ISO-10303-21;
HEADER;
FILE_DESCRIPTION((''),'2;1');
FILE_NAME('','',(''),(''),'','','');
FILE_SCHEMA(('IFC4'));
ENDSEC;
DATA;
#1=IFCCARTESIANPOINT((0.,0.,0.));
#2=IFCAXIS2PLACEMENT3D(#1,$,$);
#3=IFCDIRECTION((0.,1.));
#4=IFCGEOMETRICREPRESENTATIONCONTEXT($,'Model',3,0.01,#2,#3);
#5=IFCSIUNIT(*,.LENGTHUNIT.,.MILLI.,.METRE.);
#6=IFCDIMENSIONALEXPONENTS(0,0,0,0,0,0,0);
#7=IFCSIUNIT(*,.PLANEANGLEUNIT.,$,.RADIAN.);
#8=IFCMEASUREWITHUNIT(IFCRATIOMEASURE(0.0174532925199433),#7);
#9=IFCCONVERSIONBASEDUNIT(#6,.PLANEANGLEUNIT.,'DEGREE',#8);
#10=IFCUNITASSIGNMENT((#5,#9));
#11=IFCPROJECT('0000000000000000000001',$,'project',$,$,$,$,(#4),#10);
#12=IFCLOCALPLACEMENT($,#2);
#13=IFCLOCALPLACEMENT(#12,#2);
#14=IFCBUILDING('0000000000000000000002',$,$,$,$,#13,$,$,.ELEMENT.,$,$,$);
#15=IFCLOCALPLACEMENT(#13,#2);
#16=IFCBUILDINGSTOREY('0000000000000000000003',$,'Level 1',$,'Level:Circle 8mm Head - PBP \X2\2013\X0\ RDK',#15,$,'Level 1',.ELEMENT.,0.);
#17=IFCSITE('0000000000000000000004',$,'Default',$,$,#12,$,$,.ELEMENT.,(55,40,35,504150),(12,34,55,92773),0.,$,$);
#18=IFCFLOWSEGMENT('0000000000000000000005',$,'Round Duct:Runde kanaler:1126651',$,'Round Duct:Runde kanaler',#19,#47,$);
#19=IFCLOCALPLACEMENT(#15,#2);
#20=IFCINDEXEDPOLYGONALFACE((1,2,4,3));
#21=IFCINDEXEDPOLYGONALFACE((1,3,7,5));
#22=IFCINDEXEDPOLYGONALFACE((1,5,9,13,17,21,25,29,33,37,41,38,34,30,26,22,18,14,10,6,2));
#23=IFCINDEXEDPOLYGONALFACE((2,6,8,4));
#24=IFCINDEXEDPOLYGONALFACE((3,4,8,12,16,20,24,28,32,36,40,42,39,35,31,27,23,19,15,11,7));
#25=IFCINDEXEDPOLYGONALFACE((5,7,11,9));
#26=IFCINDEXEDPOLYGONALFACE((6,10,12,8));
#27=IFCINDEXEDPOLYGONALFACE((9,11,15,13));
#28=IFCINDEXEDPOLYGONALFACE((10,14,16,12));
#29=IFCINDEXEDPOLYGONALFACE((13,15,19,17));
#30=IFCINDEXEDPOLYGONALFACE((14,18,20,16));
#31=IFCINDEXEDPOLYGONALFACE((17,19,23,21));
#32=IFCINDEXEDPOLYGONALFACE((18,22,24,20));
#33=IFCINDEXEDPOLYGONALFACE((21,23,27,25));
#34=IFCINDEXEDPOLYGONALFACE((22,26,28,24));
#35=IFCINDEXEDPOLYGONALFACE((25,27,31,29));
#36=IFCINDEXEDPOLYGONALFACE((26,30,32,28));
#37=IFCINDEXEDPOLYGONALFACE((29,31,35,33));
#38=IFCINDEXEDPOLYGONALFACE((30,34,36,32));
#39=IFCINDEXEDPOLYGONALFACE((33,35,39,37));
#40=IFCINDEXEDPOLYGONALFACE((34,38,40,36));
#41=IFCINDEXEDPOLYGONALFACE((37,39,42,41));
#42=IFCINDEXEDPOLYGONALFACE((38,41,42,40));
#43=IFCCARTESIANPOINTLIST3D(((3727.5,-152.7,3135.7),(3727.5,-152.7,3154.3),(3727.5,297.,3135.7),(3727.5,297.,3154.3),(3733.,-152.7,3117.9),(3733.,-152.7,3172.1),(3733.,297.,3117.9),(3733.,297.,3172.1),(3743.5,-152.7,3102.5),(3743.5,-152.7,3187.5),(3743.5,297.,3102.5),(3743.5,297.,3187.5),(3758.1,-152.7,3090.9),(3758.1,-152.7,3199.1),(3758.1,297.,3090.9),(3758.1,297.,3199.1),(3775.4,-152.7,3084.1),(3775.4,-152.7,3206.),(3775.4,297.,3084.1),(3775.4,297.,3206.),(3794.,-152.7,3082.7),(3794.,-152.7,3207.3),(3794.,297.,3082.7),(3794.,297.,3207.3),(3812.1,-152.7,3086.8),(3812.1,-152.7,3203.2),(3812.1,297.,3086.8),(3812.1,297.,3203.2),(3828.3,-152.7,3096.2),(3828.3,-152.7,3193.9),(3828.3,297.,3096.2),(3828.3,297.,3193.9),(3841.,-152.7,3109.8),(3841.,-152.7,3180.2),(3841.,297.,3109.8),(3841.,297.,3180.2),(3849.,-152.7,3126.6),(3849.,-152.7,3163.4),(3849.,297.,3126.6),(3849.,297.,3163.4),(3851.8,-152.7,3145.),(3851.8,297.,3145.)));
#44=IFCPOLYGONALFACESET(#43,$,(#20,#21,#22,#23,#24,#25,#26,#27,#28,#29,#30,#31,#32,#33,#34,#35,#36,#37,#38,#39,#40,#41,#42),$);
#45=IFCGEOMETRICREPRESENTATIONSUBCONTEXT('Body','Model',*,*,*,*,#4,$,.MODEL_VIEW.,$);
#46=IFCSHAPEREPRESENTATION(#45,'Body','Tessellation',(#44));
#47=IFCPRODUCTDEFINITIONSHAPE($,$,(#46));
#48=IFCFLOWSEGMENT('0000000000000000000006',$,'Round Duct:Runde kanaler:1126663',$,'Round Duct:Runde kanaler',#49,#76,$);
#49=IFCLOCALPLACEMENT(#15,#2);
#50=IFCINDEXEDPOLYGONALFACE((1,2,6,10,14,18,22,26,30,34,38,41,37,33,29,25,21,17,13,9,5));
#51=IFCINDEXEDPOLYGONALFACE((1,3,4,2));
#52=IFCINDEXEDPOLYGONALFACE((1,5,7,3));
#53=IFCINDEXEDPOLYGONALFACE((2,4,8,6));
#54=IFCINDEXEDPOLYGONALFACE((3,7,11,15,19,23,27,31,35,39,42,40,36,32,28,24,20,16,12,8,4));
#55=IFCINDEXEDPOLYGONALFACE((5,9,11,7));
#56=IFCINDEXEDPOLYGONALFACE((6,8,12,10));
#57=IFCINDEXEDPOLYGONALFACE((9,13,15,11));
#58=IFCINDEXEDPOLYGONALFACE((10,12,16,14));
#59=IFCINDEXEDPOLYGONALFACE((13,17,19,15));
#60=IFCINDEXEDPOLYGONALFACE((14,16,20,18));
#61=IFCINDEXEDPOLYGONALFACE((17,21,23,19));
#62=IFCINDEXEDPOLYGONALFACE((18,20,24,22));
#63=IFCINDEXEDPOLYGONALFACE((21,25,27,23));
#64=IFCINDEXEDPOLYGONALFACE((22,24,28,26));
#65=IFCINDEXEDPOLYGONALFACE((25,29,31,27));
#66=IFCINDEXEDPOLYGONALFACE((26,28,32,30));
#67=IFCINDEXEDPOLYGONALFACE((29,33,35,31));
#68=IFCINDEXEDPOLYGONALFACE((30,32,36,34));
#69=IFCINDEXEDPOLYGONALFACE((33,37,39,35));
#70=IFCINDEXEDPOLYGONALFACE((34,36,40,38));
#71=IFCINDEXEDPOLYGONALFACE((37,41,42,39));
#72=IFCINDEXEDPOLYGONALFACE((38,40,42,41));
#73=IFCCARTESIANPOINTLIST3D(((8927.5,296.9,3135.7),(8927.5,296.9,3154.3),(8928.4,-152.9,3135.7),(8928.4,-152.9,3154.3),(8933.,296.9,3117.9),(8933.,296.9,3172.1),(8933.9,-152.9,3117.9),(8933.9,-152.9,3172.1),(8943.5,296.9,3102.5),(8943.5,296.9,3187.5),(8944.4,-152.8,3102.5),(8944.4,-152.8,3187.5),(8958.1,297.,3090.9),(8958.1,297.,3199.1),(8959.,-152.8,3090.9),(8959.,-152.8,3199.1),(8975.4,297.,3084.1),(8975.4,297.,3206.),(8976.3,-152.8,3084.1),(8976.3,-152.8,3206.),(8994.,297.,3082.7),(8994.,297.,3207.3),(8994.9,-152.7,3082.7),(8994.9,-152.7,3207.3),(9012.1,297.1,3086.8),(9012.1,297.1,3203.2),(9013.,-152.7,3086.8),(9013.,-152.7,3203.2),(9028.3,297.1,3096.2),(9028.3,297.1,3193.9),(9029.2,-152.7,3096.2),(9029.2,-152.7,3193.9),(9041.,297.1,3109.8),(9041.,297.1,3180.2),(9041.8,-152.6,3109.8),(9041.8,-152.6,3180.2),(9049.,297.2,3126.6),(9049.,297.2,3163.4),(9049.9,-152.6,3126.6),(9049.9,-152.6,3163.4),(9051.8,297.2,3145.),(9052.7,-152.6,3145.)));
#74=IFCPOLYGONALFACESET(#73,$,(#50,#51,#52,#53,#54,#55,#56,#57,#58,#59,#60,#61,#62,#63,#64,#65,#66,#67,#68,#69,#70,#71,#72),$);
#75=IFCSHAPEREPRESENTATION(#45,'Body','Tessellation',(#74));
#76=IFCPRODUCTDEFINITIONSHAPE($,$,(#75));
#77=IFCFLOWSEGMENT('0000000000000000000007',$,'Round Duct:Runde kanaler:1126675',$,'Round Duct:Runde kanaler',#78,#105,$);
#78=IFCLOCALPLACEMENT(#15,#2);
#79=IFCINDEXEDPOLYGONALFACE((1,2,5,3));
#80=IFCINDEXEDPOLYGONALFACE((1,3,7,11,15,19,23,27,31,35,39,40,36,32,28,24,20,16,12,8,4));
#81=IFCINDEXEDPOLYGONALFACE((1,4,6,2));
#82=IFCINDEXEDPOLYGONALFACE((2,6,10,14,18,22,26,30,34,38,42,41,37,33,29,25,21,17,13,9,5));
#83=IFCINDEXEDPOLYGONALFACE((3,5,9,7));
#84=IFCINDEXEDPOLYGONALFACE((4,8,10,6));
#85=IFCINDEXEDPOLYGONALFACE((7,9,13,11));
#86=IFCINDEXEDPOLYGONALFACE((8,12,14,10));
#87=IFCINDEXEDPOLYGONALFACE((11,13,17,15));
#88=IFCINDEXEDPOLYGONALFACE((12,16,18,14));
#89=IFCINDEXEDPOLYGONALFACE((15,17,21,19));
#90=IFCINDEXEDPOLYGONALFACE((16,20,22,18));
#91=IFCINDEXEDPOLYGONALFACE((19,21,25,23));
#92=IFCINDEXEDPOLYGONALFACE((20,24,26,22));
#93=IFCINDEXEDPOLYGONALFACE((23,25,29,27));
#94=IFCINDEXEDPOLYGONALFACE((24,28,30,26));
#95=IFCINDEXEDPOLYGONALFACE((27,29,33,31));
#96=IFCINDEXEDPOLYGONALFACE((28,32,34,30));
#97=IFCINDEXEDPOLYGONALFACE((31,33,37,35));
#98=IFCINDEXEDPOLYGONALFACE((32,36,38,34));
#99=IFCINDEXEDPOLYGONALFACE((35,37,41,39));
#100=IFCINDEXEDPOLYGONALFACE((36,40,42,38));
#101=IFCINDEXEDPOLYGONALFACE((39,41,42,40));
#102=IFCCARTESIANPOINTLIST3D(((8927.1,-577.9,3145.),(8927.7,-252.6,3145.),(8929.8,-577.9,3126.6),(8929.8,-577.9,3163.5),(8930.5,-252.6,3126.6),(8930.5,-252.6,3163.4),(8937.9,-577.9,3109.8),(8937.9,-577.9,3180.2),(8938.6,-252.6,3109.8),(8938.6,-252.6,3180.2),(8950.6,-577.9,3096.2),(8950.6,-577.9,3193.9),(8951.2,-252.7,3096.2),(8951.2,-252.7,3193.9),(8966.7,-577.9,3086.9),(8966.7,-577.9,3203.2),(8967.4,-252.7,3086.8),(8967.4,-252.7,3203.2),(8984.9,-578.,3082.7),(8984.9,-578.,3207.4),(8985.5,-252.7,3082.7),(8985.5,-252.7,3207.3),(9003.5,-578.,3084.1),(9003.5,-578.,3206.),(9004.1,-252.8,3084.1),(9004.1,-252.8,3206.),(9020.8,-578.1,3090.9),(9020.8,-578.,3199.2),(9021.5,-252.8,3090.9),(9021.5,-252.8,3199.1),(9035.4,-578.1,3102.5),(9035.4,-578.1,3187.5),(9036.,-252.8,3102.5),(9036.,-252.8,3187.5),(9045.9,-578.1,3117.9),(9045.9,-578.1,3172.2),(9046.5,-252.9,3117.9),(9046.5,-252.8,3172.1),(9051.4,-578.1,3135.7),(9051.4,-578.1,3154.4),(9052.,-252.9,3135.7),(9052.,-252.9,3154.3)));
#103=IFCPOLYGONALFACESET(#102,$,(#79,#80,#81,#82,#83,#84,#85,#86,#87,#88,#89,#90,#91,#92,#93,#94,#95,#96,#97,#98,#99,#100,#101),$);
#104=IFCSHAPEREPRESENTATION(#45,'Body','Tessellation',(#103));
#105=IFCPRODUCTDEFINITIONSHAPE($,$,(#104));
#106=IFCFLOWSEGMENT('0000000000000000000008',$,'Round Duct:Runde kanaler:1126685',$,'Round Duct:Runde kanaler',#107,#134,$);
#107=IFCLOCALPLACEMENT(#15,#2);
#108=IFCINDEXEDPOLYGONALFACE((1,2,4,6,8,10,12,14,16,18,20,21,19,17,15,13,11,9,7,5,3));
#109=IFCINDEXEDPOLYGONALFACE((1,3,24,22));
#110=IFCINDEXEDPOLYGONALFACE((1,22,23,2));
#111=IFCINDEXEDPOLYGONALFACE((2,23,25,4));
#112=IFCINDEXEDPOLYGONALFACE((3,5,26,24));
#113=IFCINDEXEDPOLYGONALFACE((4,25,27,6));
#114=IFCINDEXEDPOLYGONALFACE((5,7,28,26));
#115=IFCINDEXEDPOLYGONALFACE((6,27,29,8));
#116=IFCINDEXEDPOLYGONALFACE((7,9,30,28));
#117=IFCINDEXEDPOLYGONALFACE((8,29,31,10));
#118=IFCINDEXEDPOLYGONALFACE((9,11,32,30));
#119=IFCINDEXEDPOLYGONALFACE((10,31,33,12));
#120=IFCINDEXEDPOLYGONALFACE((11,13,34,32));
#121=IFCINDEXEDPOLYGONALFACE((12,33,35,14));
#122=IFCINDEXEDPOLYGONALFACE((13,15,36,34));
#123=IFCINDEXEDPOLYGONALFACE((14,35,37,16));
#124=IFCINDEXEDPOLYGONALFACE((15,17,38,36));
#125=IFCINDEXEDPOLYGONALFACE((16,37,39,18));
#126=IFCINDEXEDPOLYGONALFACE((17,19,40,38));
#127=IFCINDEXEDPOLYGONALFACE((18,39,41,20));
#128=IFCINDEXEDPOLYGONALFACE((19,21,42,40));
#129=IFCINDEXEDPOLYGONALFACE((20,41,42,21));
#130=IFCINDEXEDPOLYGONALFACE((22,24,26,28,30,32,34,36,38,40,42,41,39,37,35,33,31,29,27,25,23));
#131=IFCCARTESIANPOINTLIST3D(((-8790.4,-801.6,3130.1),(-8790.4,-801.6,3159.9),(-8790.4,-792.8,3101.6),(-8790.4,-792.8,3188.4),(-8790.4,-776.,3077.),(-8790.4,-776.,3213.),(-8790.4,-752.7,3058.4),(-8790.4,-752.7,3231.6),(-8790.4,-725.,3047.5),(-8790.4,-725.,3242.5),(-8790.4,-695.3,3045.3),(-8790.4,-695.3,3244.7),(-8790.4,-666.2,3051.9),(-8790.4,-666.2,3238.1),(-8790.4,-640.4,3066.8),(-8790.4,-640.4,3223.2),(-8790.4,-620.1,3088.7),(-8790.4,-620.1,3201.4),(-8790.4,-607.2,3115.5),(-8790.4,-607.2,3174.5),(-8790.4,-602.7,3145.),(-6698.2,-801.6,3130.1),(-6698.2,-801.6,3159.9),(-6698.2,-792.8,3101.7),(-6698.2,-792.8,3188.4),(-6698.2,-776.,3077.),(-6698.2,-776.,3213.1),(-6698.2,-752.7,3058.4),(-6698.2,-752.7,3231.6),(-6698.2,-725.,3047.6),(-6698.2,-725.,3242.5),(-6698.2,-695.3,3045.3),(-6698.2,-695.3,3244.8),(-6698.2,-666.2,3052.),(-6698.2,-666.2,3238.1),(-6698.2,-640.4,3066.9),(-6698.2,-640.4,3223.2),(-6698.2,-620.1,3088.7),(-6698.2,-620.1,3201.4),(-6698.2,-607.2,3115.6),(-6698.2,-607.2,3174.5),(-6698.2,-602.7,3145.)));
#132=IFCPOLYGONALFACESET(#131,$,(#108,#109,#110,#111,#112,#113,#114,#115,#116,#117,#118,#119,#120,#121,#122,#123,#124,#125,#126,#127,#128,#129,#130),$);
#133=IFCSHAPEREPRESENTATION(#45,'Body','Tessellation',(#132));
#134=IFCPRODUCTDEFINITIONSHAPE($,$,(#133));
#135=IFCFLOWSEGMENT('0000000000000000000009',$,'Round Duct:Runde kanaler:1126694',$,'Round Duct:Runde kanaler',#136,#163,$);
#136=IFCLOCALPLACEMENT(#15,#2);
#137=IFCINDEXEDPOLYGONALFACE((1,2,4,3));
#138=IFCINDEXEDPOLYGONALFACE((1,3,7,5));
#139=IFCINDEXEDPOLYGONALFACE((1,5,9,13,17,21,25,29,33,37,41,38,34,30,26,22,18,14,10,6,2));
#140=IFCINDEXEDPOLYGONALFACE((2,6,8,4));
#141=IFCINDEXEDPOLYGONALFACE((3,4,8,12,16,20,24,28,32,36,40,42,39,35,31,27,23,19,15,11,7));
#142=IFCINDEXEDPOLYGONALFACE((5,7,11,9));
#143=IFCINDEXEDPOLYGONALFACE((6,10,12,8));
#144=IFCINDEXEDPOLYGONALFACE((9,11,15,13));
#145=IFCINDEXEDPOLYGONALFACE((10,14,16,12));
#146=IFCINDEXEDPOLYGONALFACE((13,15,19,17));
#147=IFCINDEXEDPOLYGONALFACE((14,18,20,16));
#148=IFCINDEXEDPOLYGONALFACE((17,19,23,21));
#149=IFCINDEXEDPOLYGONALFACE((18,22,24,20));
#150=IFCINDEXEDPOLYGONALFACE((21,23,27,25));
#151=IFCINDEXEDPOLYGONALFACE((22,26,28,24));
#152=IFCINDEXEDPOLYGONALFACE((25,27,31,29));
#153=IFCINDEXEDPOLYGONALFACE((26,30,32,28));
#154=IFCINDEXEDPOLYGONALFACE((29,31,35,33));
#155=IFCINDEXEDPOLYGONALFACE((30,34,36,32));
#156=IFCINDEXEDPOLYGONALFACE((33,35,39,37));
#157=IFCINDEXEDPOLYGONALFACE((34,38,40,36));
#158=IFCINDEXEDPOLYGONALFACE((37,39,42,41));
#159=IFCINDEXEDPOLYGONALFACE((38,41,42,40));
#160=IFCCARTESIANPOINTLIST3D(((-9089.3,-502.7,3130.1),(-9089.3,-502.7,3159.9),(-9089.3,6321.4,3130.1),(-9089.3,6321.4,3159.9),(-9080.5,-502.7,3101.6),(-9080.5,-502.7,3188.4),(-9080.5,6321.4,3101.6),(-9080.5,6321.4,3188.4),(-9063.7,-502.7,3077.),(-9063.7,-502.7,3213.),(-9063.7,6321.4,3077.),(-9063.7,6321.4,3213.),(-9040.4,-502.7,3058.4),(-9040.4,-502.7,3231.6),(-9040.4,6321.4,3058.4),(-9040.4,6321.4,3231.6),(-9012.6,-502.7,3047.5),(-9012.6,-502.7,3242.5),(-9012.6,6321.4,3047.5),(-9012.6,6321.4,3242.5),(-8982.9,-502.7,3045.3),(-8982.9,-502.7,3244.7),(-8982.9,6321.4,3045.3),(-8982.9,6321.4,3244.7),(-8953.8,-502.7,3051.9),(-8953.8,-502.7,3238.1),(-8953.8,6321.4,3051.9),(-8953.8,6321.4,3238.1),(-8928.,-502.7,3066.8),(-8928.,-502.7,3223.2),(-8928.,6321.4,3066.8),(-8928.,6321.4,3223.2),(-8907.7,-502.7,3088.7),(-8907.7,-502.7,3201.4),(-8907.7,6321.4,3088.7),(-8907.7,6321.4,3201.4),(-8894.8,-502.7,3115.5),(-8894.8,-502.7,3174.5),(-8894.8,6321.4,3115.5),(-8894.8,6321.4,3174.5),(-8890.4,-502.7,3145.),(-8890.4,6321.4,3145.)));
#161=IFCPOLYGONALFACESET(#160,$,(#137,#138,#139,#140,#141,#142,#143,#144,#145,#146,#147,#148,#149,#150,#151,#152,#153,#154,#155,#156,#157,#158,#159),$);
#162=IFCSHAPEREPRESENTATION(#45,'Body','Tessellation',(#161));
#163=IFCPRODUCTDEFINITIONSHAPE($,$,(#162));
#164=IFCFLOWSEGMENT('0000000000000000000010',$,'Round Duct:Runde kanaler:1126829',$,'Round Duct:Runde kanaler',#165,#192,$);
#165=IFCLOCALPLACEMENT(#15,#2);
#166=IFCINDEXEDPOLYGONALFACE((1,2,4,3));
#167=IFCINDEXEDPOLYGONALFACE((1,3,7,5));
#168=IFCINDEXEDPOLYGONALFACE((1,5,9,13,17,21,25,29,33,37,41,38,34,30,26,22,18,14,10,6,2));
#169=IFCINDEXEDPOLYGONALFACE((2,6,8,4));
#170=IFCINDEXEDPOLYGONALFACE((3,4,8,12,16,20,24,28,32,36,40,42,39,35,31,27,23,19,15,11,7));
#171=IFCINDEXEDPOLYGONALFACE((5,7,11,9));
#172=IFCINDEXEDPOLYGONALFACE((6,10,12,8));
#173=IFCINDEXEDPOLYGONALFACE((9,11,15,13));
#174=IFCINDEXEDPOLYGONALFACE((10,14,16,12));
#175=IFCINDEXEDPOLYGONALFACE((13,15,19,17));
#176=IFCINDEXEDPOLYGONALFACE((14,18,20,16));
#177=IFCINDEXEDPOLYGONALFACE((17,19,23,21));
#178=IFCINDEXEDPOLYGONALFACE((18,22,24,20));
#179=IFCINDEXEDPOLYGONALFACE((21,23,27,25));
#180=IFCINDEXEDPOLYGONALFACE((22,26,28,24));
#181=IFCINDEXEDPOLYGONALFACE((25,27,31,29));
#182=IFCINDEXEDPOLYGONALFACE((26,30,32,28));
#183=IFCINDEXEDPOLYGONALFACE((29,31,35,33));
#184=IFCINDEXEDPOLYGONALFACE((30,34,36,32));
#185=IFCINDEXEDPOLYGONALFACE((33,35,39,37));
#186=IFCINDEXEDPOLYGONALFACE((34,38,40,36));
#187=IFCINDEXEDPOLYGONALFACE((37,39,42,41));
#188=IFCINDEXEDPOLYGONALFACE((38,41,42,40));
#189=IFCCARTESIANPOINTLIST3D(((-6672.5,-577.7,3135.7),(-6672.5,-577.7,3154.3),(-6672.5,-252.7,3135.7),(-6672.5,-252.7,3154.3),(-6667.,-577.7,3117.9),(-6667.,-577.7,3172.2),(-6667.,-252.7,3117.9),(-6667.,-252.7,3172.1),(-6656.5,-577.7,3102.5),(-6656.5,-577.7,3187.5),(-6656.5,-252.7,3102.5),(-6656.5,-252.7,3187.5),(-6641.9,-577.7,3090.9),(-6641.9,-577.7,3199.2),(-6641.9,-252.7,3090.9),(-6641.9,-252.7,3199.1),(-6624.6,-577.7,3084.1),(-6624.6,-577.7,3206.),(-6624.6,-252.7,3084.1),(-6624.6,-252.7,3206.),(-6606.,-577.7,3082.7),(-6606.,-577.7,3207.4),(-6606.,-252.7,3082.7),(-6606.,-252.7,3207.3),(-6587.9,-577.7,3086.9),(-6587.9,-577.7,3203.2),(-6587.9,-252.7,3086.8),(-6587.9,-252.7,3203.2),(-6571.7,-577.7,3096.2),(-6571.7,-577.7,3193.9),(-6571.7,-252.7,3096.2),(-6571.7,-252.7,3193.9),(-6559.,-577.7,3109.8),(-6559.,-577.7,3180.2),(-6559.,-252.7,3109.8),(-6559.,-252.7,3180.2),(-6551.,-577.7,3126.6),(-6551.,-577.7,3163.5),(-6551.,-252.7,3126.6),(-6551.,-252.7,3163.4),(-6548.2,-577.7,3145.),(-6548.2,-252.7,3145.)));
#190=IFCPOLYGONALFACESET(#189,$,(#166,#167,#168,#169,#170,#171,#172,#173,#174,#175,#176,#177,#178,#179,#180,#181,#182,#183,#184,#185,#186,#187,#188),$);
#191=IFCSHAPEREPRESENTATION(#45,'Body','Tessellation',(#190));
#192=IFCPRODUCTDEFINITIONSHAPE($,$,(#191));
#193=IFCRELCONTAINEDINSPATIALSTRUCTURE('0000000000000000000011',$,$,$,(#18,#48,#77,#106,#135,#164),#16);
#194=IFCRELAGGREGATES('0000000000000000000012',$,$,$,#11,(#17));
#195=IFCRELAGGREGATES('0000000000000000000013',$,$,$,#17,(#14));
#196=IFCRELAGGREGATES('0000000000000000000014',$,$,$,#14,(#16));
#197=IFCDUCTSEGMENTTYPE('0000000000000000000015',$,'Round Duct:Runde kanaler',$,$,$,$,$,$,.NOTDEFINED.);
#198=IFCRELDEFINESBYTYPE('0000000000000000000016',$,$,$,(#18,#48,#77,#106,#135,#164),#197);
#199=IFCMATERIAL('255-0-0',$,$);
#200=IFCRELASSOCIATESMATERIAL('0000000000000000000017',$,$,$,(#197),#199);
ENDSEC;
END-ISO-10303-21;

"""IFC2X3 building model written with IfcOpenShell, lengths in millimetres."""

from ifc_helpers import new_model, entity, si_unit, converted_unit, direction, frame, frame_2d, origin, origin_2d_with_axis, place, context, subcontext, project, spatial, circle, extrude, material, type_object, element, save


model = new_model("IFC2X3")

# Units and contexts
model_context = context("Model", 3, precision=0.01, world=origin(), true_north=direction((0.0, 1.0)))
body_context = subcontext(model_context, "Body", "Model", "MODEL_VIEW")
ifc_project = project(units=[si_unit("LENGTHUNIT", "METRE", prefix="MILLI"), converted_unit("PLANEANGLEUNIT", "DEGREE", entity("IfcRatioMeasure", 0.0174532925199433), si_unit("PLANEANGLEUNIT", "RADIAN"), dimensions=[0, 0, 0, 0, 0, 0, 0])], contexts=[model_context])

# Site, building, storey
site_placement = place(None, origin())
site = spatial("IfcSite", under=ifc_project, at=site_placement, Name="Default", CompositionType="ELEMENT", RefLatitude=(55, 40, 35, 504150), RefLongitude=(12, 34, 55, 92773), RefElevation=0.0)
building_placement = place(site_placement, origin())
building = spatial("IfcBuilding", under=site, at=building_placement, CompositionType="ELEMENT")
storey_placement = place(building_placement, origin())
storey = spatial("IfcBuildingStorey", under=building, at=storey_placement, Name="Level 1", ObjectType="Level:Circle 8mm Head - PBP – RDK", LongName="Level 1", CompositionType="ELEMENT", Elevation=0.0)

# Flow segments
ifc_material_1 = material(Name="255-0-0")
duct_segment_type = type_object("IfcDuctSegmentType", Name="Round Duct:Runde kanaler", PredefinedType="NOTDEFINED", material=ifc_material_1)
flow_segment_1_placement = place(storey_placement, origin())
element("IfcFlowSegment", 1, at=flow_segment_1_placement, inside=storey, type_object=duct_segment_type, Name="Round Duct:Runde kanaler:1126651", ObjectType="Round Duct:Runde kanaler", context=body_context, shape_type="SweptSolid", body=[
    extrude(circle(Radius=62.5, at=frame_2d((0.0, 0.0), x_axis=(1.0, 0.0))), frame((3789.3, -152.7, 3145.0), z_axis=(0.0, 1.0, 0.0), x_axis=(1.0, 0.0, 0.0)), (0.0, 0.0, 1.0), 449.8),
])
flow_segment_2_placement = place(storey_placement, origin())
element("IfcFlowSegment", 2, at=flow_segment_2_placement, inside=storey, type_object=duct_segment_type, Name="Round Duct:Runde kanaler:1126663", ObjectType="Round Duct:Runde kanaler", context=body_context, shape_type="SweptSolid", body=[
    extrude(circle(Radius=62.5, at=origin_2d_with_axis()), frame((8990.2, -152.7, 3145.0), z_axis=(-0.001973, 0.999998, 0.0), x_axis=(0.999998, 0.001973, 0.0)), (0.0, 0.0, 1.0), 449.8),
])
flow_segment_3_placement = place(storey_placement, origin())
element("IfcFlowSegment", 3, at=flow_segment_3_placement, inside=storey, type_object=duct_segment_type, Name="Round Duct:Runde kanaler:1126675", ObjectType="Round Duct:Runde kanaler", context=body_context, shape_type="SweptSolid", body=[
    extrude(circle(Radius=62.5, at=frame_2d((0.0, 0.0), x_axis=(1.0, 0.0))), frame((8989.6, -578.0, 3145.0), z_axis=(0.001972, 0.999998, -0.000047), x_axis=(-0.999998, 0.001972, 0.0)), (0.0, 0.0, 1.0), 325.2),
])
flow_segment_4_placement = place(storey_placement, origin())
element("IfcFlowSegment", 4, at=flow_segment_4_placement, inside=storey, type_object=duct_segment_type, Name="Round Duct:Runde kanaler:1126685", ObjectType="Round Duct:Runde kanaler", context=body_context, shape_type="SweptSolid", body=[
    extrude(circle(Radius=100.0, at=frame_2d((0.0, 0.0), x_axis=(1.0, 0.0))), frame((-8790.4, -702.7, 3145.0), z_axis=(1.0, 0.0, 0.000011), x_axis=(0.0, 1.0, 0.0)), (0.0, 0.0, 1.0), 2092.2),
])
flow_segment_5_placement = place(storey_placement, origin())
element("IfcFlowSegment", 5, at=flow_segment_5_placement, inside=storey, type_object=duct_segment_type, Name="Round Duct:Runde kanaler:1126694", ObjectType="Round Duct:Runde kanaler", context=body_context, shape_type="SweptSolid", body=[
    extrude(circle(Radius=100.0, at=frame_2d((0.0, 0.0), x_axis=(1.0, 0.0))), frame((-8990.4, -502.7, 3145.0), z_axis=(0.0, 1.0, 0.0), x_axis=(1.0, 0.0, 0.0)), (0.0, 0.0, 1.0), 6824.2),
])
flow_segment_6_placement = place(storey_placement, origin())
element("IfcFlowSegment", 6, at=flow_segment_6_placement, inside=storey, type_object=duct_segment_type, Name="Round Duct:Runde kanaler:1126829", ObjectType="Round Duct:Runde kanaler", context=body_context, shape_type="SweptSolid", body=[
    extrude(circle(Radius=62.5, at=frame_2d((0.0, 0.0), x_axis=(1.0, 0.0))), frame((-6610.7, -252.7, 3145.0), z_axis=(0.0, -1.0, 0.000034), x_axis=(1.0, 0.0, 0.0)), (0.0, 0.0, 1.0), 325.0),
])

save(model, "model.ifc")
